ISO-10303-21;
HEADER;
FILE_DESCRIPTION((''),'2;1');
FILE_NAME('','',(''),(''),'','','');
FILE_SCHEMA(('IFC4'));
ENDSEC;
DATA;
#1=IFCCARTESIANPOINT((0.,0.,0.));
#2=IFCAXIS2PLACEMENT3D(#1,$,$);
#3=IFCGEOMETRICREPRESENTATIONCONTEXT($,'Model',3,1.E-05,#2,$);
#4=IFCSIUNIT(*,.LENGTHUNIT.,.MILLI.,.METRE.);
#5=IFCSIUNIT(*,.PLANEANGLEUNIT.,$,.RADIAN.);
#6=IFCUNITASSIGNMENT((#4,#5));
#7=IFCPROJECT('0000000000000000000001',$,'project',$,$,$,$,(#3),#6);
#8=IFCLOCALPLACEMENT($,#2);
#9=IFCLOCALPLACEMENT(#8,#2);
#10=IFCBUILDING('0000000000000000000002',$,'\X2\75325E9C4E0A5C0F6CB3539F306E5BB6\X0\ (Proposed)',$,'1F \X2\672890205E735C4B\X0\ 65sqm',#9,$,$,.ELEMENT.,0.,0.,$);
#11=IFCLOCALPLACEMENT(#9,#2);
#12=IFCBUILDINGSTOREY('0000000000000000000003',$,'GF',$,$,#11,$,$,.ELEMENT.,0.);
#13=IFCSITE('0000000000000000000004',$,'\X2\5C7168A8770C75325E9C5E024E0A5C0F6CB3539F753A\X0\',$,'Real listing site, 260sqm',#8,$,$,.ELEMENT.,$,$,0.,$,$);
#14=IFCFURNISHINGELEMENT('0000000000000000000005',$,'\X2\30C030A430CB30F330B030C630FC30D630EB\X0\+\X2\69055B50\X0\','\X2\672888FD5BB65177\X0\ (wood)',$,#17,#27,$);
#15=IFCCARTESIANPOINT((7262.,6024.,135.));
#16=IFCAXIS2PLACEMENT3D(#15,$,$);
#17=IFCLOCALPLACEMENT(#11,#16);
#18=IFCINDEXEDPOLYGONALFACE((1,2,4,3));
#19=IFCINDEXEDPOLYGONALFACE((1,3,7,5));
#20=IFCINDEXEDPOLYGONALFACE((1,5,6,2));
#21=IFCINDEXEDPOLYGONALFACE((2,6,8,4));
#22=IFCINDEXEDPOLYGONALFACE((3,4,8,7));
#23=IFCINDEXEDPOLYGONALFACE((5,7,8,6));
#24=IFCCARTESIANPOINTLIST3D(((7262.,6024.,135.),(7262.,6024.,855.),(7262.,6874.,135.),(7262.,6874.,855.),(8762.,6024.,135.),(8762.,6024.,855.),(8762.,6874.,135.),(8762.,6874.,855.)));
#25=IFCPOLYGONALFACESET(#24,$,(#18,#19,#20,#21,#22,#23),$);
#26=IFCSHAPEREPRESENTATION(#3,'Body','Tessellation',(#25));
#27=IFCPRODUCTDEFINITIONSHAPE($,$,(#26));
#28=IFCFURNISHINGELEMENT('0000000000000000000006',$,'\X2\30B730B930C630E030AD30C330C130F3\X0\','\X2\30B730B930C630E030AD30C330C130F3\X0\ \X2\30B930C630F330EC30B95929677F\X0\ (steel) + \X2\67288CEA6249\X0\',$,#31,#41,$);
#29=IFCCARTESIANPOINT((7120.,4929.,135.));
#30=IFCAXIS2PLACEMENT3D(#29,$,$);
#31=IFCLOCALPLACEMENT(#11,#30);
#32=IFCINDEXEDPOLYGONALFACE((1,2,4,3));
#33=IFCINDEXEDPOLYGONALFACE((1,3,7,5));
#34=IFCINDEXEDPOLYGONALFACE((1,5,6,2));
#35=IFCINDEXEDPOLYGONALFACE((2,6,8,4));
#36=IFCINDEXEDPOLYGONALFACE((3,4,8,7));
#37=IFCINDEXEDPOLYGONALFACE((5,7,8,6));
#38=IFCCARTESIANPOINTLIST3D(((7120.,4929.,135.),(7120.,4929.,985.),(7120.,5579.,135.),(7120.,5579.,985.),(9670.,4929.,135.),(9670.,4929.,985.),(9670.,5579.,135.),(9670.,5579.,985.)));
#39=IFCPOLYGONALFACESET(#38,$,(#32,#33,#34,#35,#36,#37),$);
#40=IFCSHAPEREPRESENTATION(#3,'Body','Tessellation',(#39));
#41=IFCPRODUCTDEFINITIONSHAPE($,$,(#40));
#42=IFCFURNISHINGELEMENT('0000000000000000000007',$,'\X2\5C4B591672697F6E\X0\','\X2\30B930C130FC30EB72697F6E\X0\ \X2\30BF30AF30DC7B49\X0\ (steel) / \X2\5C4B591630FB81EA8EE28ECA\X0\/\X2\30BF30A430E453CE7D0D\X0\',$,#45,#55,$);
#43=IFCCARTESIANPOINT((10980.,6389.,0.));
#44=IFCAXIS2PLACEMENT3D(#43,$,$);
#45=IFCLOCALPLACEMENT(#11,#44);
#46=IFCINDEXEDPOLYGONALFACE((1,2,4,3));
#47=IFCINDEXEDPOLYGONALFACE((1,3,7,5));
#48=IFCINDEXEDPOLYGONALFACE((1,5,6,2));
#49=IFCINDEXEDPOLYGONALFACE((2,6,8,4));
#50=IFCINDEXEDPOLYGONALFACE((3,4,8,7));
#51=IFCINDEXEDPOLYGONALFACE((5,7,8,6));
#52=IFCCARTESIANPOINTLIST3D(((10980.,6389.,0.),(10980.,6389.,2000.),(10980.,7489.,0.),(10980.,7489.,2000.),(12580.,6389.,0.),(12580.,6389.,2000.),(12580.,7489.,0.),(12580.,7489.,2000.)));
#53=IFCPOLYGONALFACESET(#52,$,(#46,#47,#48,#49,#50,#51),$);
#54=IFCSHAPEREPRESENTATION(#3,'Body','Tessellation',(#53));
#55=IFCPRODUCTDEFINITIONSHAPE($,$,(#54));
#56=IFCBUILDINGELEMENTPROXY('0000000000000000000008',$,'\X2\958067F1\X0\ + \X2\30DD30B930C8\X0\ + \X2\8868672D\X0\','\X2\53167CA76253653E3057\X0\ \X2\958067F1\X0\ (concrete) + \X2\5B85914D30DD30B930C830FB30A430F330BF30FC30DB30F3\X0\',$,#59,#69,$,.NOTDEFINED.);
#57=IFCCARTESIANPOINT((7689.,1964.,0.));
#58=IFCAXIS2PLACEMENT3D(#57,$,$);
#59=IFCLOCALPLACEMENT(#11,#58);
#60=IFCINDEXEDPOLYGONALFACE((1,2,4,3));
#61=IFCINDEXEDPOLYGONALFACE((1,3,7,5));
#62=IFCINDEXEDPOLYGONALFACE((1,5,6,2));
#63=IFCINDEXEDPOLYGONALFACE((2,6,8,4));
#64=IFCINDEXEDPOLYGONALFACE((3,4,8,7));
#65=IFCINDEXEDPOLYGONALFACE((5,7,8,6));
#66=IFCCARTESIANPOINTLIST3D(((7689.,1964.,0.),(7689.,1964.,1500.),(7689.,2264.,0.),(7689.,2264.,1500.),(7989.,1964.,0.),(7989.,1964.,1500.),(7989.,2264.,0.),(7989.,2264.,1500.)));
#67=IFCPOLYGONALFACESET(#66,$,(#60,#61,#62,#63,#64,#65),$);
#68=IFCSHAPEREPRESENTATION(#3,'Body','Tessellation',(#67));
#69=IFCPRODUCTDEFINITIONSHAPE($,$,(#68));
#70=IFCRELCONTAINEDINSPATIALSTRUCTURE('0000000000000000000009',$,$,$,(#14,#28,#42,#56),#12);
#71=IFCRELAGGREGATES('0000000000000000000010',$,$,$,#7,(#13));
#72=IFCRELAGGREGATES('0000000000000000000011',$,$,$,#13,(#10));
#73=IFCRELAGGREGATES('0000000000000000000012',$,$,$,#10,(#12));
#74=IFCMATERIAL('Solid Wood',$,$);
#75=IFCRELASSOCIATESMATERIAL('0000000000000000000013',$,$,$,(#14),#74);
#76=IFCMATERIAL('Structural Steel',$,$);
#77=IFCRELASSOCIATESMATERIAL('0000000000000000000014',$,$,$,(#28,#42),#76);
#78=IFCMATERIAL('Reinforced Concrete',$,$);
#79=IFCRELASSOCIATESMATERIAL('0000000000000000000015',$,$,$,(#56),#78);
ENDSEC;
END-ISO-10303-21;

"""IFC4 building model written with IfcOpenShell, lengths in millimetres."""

from ifc_helpers import new_model, si_unit, frame, frame_2d, origin, place, context, project, spatial, rectangle, extrude, material, element, save


model = new_model("IFC4")

# Units and contexts
model_context = context("Model", 3, precision=1e-05, world=origin())
ifc_project = project(units=[si_unit("LENGTHUNIT", "METRE", prefix="MILLI"), si_unit("PLANEANGLEUNIT", "RADIAN")], contexts=[model_context])

# Site, building, storey
site_placement = place(None, origin())
site = spatial("IfcSite", under=ifc_project, at=site_placement, Name="山梨県甲府市上小河原町", ObjectType="Real listing site, 260sqm", CompositionType="ELEMENT", RefElevation=0.0)
building_placement = place(site_placement, origin())
building = spatial("IfcBuilding", under=site, at=building_placement, Name="甲府上小河原の家 (Proposed)", ObjectType="1F 木造平屋 65sqm", CompositionType="ELEMENT", ElevationOfRefHeight=0.0, ElevationOfTerrain=0.0)
storey_placement = place(building_placement, origin())
storey = spatial("IfcBuildingStorey", under=building, at=storey_placement, Name="GF", CompositionType="ELEMENT", Elevation=0.0)

# Shared definitions
ifc_material_1 = material(Name="Solid Wood")

# Shared definitions
ifc_material_2 = material(Name="Structural Steel")

# Shared definitions
ifc_material_3 = material(Name="Reinforced Concrete")

# Furnishing elements
furnishing_1_placement = place(storey_placement, frame((7262.0, 6024.0, 135.0)))
element("IfcFurnishingElement", 1, at=furnishing_1_placement, inside=storey, material=ifc_material_1, Name="ダイニングテーブル+椅子", Description="木製家具 (wood)", context=model_context, shape_type="SweptSolid", body=[
    extrude(rectangle(XDim=1500.0, YDim=850.0, at=frame_2d((750.0, 425.0))), frame((7262.0, 6024.0, 135.0)), (0.0, 0.0, 1.0), 720.0),
])
furnishing_2_placement = place(storey_placement, frame((7120.0, 4929.0, 135.0)))
element("IfcFurnishingElement", 2, at=furnishing_2_placement, inside=storey, material=ifc_material_2, Name="システムキッチン", Description="システムキッチン ステンレス天板 (steel) + 木質扉", context=model_context, shape_type="SweptSolid", body=[
    extrude(rectangle(XDim=2550.0, YDim=650.0, at=frame_2d((1275.0, 325.0))), frame((7120.0, 4929.0, 135.0)), (0.0, 0.0, 1.0), 850.0),
])
furnishing_3_placement = place(storey_placement, frame((10980.0, 6389.0, 0.0)))
element("IfcFurnishingElement", 3, at=furnishing_3_placement, inside=storey, material=ifc_material_2, Name="屋外物置", Description="スチール物置 タクボ等 (steel) / 屋外・自転車/タイヤ収納", context=model_context, shape_type="SweptSolid", body=[
    extrude(rectangle(XDim=1600.0, YDim=1100.0, at=frame_2d((800.0, 550.0))), frame((10980.0, 6389.0, 0.0)), (0.0, 0.0, 1.0), 2000.0),
])

# Building element proxy
proxy_placement = place(storey_placement, frame((7689.0, 1964.0, 0.0)))
element("IfcBuildingElementProxy", 4, at=proxy_placement, inside=storey, material=ifc_material_3, Name="門柱 + ポスト + 表札", Description="化粧打放し 門柱 (concrete) + 宅配ポスト・インターホン", PredefinedType="NOTDEFINED", context=model_context, shape_type="SweptSolid", body=[
    extrude(rectangle(XDim=300.0, YDim=300.0, at=frame_2d((150.0, 150.0))), frame((7689.0, 1964.0, 0.0)), (0.0, 0.0, 1.0), 1500.0),
])

save(model, "model.ifc")
